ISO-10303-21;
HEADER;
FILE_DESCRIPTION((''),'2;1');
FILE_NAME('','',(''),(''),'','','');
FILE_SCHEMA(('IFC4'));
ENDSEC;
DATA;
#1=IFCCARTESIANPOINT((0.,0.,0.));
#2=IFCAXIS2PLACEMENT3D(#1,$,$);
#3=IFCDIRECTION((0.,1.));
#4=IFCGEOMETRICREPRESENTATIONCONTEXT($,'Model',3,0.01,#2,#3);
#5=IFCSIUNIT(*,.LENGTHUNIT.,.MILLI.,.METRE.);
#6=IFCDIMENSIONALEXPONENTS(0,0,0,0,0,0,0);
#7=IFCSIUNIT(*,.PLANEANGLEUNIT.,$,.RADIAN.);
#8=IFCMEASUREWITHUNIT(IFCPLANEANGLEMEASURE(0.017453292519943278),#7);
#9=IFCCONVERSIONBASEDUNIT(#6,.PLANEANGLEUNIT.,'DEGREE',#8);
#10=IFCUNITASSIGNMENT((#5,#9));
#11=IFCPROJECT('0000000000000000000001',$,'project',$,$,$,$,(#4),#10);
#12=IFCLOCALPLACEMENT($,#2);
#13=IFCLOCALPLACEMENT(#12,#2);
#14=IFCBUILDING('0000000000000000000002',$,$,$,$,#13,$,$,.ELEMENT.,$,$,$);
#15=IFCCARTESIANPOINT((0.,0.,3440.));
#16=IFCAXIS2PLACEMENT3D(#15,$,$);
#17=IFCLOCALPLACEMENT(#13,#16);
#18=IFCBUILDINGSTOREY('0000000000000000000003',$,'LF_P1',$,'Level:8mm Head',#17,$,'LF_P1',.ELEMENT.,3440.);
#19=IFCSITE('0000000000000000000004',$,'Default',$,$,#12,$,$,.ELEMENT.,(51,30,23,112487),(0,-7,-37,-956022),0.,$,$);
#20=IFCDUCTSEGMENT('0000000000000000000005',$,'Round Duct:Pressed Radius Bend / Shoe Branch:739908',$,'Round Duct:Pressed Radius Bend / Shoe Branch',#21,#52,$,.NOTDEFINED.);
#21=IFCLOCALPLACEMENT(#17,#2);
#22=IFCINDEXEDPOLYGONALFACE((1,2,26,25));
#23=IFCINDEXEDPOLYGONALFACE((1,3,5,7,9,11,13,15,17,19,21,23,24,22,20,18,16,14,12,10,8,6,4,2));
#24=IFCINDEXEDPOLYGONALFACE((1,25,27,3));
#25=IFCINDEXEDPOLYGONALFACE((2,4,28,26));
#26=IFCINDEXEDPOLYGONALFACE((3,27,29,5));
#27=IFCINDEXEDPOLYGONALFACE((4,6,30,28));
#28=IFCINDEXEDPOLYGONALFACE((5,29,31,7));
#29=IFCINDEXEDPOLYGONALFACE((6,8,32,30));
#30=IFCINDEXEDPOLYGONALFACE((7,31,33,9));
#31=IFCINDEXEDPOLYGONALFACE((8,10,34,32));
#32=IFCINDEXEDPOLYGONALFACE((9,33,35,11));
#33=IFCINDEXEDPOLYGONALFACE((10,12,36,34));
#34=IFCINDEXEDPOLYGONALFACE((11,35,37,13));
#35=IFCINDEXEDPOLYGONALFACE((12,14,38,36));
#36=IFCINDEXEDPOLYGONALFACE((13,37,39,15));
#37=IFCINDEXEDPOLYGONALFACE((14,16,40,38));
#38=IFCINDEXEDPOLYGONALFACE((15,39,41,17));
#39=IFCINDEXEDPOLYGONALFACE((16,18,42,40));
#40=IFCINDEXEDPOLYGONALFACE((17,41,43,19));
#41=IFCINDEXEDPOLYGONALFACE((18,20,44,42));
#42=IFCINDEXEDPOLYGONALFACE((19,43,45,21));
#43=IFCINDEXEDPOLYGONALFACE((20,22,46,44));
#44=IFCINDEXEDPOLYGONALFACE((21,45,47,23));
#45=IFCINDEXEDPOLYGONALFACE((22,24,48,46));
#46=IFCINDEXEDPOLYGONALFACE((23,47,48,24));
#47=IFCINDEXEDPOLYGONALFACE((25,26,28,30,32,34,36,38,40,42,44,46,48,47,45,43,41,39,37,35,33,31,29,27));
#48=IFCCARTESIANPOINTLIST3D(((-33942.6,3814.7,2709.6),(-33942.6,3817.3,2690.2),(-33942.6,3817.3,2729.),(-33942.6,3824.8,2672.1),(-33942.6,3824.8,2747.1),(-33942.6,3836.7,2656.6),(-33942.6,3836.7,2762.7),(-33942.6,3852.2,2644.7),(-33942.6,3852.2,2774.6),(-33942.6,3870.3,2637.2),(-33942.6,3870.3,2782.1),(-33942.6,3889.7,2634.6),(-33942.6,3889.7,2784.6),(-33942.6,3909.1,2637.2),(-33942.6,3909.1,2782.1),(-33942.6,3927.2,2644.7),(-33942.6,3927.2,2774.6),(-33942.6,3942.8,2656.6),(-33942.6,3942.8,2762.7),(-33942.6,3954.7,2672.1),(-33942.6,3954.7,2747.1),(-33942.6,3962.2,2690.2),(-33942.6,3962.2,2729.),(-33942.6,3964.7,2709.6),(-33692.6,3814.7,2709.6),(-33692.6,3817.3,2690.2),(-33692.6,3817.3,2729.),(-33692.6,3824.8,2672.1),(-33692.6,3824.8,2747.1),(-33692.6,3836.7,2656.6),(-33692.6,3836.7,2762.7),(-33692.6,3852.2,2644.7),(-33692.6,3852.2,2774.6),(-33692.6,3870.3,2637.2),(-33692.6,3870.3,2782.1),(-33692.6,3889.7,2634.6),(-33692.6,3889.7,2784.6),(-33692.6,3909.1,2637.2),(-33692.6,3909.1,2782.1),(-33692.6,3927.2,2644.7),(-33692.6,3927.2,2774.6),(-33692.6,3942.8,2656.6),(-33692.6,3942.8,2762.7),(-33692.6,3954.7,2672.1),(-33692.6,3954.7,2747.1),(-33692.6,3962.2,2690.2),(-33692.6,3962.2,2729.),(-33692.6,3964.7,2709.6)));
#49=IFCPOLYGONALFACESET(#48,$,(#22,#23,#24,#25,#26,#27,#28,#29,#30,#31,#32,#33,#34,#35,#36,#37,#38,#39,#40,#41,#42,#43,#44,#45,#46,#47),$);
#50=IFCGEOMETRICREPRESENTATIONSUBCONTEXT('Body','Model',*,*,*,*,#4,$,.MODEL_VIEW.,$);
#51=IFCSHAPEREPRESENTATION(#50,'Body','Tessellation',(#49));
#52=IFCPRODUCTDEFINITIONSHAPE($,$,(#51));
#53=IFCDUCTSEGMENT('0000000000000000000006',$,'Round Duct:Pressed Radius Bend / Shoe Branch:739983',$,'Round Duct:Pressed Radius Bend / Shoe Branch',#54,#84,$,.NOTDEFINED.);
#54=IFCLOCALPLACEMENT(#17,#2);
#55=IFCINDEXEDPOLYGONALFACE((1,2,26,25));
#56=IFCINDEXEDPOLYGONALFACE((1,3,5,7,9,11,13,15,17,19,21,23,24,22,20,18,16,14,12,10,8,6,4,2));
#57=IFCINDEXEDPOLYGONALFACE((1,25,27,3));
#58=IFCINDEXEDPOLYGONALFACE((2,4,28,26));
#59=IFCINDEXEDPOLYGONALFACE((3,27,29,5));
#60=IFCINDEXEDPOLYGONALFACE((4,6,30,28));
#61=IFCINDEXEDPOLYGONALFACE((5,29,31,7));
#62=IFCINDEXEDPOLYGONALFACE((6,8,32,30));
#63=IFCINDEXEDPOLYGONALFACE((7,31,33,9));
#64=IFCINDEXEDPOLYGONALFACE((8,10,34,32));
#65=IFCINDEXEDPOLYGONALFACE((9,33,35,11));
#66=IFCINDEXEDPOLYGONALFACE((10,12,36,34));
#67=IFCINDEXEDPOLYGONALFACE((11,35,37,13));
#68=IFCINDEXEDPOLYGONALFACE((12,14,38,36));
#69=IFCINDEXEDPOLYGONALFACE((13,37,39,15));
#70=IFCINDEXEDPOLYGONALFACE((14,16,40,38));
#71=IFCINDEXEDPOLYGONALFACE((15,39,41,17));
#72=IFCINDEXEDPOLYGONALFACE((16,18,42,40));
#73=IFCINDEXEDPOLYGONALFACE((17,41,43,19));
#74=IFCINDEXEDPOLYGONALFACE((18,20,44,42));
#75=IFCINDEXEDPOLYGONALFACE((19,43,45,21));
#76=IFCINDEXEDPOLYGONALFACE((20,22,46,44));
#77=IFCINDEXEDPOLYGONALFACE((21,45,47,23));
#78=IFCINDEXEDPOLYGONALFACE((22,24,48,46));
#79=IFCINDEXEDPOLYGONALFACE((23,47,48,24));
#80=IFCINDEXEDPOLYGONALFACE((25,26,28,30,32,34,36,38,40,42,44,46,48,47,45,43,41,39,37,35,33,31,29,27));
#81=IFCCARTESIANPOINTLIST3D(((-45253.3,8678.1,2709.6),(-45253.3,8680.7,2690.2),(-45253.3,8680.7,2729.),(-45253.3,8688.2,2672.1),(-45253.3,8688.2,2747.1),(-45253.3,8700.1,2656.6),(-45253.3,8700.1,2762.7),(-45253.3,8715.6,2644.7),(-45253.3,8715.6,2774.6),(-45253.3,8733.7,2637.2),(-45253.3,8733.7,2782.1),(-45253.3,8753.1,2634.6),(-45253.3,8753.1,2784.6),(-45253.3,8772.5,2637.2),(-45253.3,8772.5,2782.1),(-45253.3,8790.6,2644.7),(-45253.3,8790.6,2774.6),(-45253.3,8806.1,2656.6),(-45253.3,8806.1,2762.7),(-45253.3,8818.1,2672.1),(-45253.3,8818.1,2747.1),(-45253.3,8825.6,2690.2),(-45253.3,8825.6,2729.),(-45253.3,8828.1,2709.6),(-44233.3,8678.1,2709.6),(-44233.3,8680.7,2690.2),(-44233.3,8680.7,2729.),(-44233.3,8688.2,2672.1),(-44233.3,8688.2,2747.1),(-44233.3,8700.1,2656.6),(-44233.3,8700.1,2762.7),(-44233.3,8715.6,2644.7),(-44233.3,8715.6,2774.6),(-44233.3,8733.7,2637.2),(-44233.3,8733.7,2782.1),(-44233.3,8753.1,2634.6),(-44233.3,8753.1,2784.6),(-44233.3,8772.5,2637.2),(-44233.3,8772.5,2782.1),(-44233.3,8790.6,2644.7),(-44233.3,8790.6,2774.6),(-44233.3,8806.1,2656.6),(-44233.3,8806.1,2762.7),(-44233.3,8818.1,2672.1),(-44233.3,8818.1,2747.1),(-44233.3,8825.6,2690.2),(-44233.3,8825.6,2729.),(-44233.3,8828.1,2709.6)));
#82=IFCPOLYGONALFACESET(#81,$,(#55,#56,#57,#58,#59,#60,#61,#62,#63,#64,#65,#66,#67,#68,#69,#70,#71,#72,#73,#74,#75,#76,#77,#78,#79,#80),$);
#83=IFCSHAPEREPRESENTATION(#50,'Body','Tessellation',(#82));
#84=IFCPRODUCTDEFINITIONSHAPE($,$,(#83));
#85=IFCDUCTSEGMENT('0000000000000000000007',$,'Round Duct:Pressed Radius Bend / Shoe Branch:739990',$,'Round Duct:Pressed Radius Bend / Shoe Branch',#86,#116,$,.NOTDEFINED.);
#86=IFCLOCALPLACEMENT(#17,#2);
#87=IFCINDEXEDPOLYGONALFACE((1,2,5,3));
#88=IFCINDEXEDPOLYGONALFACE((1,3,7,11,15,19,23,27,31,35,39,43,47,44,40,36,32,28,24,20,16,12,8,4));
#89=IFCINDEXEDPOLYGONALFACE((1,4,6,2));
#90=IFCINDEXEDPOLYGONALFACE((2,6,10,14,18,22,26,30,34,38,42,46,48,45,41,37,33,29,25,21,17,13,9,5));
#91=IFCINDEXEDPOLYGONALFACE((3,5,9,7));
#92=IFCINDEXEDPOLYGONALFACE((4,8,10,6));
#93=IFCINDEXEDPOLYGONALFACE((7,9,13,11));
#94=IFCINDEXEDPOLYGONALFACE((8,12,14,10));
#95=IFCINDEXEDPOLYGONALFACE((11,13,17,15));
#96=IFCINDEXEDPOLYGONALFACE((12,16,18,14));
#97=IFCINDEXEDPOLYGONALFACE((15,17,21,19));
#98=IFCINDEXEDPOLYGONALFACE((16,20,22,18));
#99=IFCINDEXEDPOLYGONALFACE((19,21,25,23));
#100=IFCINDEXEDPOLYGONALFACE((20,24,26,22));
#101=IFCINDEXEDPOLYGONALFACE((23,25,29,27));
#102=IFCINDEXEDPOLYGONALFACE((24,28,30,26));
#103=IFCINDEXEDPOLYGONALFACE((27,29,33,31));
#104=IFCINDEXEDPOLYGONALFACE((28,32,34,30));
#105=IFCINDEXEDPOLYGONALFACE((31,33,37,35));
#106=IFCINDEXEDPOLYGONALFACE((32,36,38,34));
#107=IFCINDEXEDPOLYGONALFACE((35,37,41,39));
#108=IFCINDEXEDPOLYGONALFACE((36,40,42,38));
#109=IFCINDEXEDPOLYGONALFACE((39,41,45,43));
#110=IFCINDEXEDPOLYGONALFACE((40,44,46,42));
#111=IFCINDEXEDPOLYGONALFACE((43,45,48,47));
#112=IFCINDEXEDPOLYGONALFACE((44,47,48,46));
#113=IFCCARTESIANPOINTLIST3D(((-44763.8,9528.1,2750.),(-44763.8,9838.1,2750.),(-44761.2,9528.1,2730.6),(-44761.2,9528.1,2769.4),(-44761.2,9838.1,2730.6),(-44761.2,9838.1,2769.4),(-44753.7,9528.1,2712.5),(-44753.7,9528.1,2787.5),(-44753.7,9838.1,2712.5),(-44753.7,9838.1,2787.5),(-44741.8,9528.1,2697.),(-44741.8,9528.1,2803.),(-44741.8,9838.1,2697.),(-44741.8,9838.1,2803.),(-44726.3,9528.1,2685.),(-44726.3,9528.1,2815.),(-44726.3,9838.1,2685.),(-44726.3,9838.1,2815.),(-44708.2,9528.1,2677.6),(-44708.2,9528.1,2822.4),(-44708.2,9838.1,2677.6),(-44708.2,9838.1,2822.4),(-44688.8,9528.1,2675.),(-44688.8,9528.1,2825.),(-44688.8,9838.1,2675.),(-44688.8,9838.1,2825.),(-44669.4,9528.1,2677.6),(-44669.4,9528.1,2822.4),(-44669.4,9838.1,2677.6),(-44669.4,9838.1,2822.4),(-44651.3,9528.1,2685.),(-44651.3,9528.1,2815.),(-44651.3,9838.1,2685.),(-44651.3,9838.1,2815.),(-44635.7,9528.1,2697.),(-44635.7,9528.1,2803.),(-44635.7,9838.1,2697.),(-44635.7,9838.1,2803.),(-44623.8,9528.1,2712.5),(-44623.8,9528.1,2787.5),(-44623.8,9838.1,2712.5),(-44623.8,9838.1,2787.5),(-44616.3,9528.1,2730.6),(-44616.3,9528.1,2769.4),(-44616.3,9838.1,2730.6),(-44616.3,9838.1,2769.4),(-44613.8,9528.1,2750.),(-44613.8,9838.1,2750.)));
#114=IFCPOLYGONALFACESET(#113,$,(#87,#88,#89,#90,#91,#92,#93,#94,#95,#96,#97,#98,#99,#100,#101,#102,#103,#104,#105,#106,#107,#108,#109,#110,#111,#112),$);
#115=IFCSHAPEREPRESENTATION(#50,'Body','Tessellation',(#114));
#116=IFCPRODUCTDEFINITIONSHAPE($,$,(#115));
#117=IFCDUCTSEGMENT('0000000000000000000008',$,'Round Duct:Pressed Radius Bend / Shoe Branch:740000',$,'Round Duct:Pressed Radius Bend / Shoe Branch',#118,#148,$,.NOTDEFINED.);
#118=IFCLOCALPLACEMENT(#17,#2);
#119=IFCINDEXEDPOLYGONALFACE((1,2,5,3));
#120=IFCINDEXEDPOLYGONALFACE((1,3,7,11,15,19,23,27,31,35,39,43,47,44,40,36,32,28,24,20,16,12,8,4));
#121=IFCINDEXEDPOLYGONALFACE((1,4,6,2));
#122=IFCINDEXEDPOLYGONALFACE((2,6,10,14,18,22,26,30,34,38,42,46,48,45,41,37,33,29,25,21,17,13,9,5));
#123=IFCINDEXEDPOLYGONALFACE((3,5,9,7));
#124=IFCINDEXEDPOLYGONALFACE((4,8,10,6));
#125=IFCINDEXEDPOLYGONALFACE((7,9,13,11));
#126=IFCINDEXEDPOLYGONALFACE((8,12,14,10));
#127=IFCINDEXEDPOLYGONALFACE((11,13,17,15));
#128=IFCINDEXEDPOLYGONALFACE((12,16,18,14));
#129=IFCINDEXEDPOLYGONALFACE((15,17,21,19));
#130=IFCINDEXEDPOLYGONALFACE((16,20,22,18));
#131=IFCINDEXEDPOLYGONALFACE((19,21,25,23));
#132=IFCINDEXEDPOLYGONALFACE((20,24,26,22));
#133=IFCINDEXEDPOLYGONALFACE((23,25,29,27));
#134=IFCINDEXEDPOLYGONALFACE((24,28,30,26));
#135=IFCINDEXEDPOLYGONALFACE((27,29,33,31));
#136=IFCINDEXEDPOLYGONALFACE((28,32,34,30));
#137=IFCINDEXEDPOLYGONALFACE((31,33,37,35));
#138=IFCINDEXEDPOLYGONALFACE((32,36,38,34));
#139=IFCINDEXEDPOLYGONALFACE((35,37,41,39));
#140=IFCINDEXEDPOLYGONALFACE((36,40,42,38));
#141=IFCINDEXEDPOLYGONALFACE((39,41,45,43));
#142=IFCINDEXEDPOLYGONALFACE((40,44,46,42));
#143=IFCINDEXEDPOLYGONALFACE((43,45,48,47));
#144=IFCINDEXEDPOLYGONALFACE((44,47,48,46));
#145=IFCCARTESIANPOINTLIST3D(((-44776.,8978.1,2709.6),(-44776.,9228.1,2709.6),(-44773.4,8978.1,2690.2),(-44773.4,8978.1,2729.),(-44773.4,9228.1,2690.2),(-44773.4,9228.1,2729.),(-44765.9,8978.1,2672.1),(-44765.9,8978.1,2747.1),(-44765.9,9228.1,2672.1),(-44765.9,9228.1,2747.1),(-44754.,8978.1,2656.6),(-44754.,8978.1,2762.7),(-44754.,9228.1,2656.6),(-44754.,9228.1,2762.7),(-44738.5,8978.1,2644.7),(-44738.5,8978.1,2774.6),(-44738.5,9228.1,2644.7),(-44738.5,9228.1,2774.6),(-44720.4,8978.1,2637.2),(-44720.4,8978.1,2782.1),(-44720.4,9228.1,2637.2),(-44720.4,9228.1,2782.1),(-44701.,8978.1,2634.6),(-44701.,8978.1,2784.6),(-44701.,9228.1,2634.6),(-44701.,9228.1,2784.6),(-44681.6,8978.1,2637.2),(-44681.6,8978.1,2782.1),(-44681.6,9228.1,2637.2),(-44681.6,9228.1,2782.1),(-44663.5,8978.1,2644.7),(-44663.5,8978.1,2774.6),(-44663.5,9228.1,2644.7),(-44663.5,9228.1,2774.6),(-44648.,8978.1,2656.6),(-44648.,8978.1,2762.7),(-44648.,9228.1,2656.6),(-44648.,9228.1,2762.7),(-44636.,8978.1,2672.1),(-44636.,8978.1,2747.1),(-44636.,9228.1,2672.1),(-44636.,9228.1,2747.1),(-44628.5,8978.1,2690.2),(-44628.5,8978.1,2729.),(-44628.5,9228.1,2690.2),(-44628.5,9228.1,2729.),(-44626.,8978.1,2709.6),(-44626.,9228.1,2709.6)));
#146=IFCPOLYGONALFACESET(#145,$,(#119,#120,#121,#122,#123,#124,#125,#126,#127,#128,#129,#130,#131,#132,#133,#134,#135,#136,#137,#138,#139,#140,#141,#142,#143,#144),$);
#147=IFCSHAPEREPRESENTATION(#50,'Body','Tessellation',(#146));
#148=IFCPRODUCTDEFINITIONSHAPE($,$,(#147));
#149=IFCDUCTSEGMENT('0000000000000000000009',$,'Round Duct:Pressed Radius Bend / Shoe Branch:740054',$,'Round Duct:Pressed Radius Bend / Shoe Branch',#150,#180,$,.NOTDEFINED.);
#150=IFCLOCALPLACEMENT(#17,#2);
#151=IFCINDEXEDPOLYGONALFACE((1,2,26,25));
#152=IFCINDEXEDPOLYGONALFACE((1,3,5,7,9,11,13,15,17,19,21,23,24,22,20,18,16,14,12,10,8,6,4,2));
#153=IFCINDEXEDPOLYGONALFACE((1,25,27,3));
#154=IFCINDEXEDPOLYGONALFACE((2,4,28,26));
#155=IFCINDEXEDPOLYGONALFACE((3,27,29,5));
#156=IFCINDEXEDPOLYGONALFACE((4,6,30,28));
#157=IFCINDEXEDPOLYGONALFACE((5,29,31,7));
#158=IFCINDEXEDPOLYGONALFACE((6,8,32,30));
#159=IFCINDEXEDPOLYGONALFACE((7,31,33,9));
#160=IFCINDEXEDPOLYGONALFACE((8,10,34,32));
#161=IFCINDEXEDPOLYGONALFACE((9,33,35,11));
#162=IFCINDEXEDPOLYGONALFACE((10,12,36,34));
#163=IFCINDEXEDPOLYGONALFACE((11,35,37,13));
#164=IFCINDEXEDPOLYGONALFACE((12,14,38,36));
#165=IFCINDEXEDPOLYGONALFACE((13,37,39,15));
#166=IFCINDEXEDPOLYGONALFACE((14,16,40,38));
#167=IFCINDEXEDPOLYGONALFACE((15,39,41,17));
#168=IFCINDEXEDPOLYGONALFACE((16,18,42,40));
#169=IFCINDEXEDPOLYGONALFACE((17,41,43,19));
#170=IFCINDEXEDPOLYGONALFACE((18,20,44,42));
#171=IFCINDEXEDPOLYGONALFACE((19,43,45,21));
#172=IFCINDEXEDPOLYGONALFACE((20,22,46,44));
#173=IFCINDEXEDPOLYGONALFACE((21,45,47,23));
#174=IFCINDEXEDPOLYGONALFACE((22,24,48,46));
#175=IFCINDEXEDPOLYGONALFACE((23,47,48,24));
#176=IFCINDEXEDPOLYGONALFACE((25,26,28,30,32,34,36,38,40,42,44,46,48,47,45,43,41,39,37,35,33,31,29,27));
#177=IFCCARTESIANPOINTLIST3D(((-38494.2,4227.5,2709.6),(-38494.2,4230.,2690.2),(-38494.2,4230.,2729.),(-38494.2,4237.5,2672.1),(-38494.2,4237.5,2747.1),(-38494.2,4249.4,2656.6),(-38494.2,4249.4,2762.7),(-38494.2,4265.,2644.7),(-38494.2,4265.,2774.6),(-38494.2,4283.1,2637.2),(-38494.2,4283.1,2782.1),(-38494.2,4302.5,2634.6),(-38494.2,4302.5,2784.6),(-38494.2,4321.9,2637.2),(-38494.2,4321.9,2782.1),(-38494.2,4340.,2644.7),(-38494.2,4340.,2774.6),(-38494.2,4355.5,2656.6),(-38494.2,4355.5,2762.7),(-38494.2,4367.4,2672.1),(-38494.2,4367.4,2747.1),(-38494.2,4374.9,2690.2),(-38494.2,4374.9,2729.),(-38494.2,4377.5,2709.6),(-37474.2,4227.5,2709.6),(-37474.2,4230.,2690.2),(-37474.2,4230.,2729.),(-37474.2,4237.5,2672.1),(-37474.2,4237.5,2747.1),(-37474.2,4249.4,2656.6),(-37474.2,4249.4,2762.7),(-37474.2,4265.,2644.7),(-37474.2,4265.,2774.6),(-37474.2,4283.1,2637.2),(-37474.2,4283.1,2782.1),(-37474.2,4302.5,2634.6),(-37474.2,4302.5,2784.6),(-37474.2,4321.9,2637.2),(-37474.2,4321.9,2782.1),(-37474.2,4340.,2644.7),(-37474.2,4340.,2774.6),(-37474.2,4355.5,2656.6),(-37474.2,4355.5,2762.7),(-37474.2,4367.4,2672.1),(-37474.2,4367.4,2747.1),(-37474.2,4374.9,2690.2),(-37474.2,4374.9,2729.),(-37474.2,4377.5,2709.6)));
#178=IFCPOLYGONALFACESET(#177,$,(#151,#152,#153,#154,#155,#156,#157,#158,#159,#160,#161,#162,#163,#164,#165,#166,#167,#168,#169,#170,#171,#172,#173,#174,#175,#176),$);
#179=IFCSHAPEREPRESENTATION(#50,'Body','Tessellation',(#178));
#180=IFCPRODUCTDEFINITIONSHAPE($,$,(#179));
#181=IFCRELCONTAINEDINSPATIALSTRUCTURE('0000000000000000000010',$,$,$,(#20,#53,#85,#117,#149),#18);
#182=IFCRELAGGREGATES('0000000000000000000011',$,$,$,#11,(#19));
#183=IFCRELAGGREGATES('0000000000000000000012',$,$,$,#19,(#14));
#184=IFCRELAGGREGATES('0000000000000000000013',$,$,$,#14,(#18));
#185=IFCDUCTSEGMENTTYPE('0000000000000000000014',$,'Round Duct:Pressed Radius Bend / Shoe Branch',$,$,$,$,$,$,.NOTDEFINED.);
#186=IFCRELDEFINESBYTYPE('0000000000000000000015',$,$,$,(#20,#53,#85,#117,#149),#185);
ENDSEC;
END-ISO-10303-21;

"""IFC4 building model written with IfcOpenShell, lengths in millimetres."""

from ifc_helpers import new_model, entity, si_unit, converted_unit, direction, frame, origin, place, context, subcontext, project, spatial, arc, indexed_curve, outline, extrude, type_object, element, save


model = new_model("IFC4")

# Units and contexts
model_context = context("Model", 3, precision=0.01, world=origin(), true_north=direction((0.0, 1.0)))
body_context = subcontext(model_context, "Body", "Model", "MODEL_VIEW")
ifc_project = project(units=[si_unit("LENGTHUNIT", "METRE", prefix="MILLI"), converted_unit("PLANEANGLEUNIT", "DEGREE", entity("IfcPlaneAngleMeasure", 0.017453292519943278), si_unit("PLANEANGLEUNIT", "RADIAN"), dimensions=[0, 0, 0, 0, 0, 0, 0])], contexts=[model_context])

# Site, building, storey
site_placement = place(None, origin())
site = spatial("IfcSite", under=ifc_project, at=site_placement, Name="Default", CompositionType="ELEMENT", RefLatitude=(51, 30, 23, 112487), RefLongitude=(0, -7, -37, -956022), RefElevation=0.0)
building_placement = place(site_placement, origin())
building = spatial("IfcBuilding", under=site, at=building_placement, CompositionType="ELEMENT")
storey_placement = place(building_placement, frame((0.0, 0.0, 3440.0)))
storey = spatial("IfcBuildingStorey", under=building, at=storey_placement, Name="LF_P1", ObjectType="Level:8mm Head", LongName="LF_P1", CompositionType="ELEMENT", Elevation=3440.0)

# Duct segments
duct_segment_type_1 = type_object("IfcDuctSegmentType", Name="Round Duct:Pressed Radius Bend / Shoe Branch", PredefinedType="NOTDEFINED")
duct_segment_1_placement = place(storey_placement, origin())
element("IfcDuctSegment", 1, at=duct_segment_1_placement, inside=storey, type_object=duct_segment_type_1, Name="Round Duct:Pressed Radius Bend / Shoe Branch:739908", ObjectType="Round Duct:Pressed Radius Bend / Shoe Branch", PredefinedType="NOTDEFINED", context=body_context, shape_type="SweptSolid", body=[
    extrude(outline(indexed_curve([(75.0, 0.0), (53.0, 53.0), (0.0, 75.0), (-53.0, 53.0), (-75.0, 0.0), (-53.0, -53.0), (0.0, -75.0), (53.0, -53.0)], segments=[arc(1, 2, 3), arc(3, 4, 5), arc(5, 6, 7), arc(7, 8, 1)], self_intersect=False)), frame((-33942.6, 3889.7, 2709.6), z_axis=(1.0, 0.0, 0.0), x_axis=(0.0, -1.0, 0.0)), (0.0, 0.0, 1.0), 250.0),
])
duct_segment_2_placement = place(storey_placement, origin())
element("IfcDuctSegment", 2, at=duct_segment_2_placement, inside=storey, type_object=duct_segment_type_1, Name="Round Duct:Pressed Radius Bend / Shoe Branch:739983", ObjectType="Round Duct:Pressed Radius Bend / Shoe Branch", PredefinedType="NOTDEFINED", context=body_context, shape_type="SweptSolid", body=[
    extrude(outline(indexed_curve([(75.0, 0.0), (53.0, 53.0), (0.0, 75.0), (-53.0, 53.0), (-75.0, 0.0), (-53.0, -53.0), (0.0, -75.0), (53.0, -53.0)], segments=[arc(1, 2, 3), arc(3, 4, 5), arc(5, 6, 7), arc(7, 8, 1)], self_intersect=False)), frame((-45253.3, 8753.1, 2709.6), z_axis=(1.0, 0.0, 0.0), x_axis=(0.0, 1.0, 0.0)), (0.0, 0.0, 1.0), 1020.0),
])
duct_segment_3_placement = place(storey_placement, origin())
element("IfcDuctSegment", 3, at=duct_segment_3_placement, inside=storey, type_object=duct_segment_type_1, Name="Round Duct:Pressed Radius Bend / Shoe Branch:739990", ObjectType="Round Duct:Pressed Radius Bend / Shoe Branch", PredefinedType="NOTDEFINED", context=body_context, shape_type="SweptSolid", body=[
    extrude(outline(indexed_curve([(75.0, 0.0), (53.0, 53.0), (0.0, 75.0), (-53.0, 53.0), (-75.0, 0.0), (-53.0, -53.0), (0.0, -75.0), (53.0, -53.0)], segments=[arc(1, 2, 3), arc(3, 4, 5), arc(5, 6, 7), arc(7, 8, 1)], self_intersect=False)), frame((-44688.8, 9528.1, 2750.0), z_axis=(0.0, 1.0, 0.0), x_axis=(-1.0, 0.0, 0.0)), (0.0, 0.0, 1.0), 310.0),
])
duct_segment_4_placement = place(storey_placement, origin())
element("IfcDuctSegment", 4, at=duct_segment_4_placement, inside=storey, type_object=duct_segment_type_1, Name="Round Duct:Pressed Radius Bend / Shoe Branch:740000", ObjectType="Round Duct:Pressed Radius Bend / Shoe Branch", PredefinedType="NOTDEFINED", context=body_context, shape_type="SweptSolid", body=[
    extrude(outline(indexed_curve([(75.0, 0.0), (53.0, 53.0), (0.0, 75.0), (-53.0, 53.0), (-75.0, 0.0), (-53.0, -53.0), (0.0, -75.0), (53.0, -53.0)], segments=[arc(1, 2, 3), arc(3, 4, 5), arc(5, 6, 7), arc(7, 8, 1)], self_intersect=False)), frame((-44701.0, 8978.1, 2709.6), z_axis=(0.0, 1.0, 0.0), x_axis=(1.0, 0.0, 0.0)), (0.0, 0.0, 1.0), 250.0),
])
duct_segment_5_placement = place(storey_placement, origin())
element("IfcDuctSegment", 5, at=duct_segment_5_placement, inside=storey, type_object=duct_segment_type_1, Name="Round Duct:Pressed Radius Bend / Shoe Branch:740054", ObjectType="Round Duct:Pressed Radius Bend / Shoe Branch", PredefinedType="NOTDEFINED", context=body_context, shape_type="SweptSolid", body=[
    extrude(outline(indexed_curve([(75.0, 0.0), (53.0, 53.0), (0.0, 75.0), (-53.0, 53.0), (-75.0, 0.0), (-53.0, -53.0), (0.0, -75.0), (53.0, -53.0)], segments=[arc(1, 2, 3), arc(3, 4, 5), arc(5, 6, 7), arc(7, 8, 1)], self_intersect=False)), frame((-38494.2, 4302.5, 2709.6), z_axis=(1.0, 0.0, 0.0), x_axis=(0.0, 1.0, 0.0)), (0.0, 0.0, 1.0), 1020.0),
])

save(model, "model.ifc")
